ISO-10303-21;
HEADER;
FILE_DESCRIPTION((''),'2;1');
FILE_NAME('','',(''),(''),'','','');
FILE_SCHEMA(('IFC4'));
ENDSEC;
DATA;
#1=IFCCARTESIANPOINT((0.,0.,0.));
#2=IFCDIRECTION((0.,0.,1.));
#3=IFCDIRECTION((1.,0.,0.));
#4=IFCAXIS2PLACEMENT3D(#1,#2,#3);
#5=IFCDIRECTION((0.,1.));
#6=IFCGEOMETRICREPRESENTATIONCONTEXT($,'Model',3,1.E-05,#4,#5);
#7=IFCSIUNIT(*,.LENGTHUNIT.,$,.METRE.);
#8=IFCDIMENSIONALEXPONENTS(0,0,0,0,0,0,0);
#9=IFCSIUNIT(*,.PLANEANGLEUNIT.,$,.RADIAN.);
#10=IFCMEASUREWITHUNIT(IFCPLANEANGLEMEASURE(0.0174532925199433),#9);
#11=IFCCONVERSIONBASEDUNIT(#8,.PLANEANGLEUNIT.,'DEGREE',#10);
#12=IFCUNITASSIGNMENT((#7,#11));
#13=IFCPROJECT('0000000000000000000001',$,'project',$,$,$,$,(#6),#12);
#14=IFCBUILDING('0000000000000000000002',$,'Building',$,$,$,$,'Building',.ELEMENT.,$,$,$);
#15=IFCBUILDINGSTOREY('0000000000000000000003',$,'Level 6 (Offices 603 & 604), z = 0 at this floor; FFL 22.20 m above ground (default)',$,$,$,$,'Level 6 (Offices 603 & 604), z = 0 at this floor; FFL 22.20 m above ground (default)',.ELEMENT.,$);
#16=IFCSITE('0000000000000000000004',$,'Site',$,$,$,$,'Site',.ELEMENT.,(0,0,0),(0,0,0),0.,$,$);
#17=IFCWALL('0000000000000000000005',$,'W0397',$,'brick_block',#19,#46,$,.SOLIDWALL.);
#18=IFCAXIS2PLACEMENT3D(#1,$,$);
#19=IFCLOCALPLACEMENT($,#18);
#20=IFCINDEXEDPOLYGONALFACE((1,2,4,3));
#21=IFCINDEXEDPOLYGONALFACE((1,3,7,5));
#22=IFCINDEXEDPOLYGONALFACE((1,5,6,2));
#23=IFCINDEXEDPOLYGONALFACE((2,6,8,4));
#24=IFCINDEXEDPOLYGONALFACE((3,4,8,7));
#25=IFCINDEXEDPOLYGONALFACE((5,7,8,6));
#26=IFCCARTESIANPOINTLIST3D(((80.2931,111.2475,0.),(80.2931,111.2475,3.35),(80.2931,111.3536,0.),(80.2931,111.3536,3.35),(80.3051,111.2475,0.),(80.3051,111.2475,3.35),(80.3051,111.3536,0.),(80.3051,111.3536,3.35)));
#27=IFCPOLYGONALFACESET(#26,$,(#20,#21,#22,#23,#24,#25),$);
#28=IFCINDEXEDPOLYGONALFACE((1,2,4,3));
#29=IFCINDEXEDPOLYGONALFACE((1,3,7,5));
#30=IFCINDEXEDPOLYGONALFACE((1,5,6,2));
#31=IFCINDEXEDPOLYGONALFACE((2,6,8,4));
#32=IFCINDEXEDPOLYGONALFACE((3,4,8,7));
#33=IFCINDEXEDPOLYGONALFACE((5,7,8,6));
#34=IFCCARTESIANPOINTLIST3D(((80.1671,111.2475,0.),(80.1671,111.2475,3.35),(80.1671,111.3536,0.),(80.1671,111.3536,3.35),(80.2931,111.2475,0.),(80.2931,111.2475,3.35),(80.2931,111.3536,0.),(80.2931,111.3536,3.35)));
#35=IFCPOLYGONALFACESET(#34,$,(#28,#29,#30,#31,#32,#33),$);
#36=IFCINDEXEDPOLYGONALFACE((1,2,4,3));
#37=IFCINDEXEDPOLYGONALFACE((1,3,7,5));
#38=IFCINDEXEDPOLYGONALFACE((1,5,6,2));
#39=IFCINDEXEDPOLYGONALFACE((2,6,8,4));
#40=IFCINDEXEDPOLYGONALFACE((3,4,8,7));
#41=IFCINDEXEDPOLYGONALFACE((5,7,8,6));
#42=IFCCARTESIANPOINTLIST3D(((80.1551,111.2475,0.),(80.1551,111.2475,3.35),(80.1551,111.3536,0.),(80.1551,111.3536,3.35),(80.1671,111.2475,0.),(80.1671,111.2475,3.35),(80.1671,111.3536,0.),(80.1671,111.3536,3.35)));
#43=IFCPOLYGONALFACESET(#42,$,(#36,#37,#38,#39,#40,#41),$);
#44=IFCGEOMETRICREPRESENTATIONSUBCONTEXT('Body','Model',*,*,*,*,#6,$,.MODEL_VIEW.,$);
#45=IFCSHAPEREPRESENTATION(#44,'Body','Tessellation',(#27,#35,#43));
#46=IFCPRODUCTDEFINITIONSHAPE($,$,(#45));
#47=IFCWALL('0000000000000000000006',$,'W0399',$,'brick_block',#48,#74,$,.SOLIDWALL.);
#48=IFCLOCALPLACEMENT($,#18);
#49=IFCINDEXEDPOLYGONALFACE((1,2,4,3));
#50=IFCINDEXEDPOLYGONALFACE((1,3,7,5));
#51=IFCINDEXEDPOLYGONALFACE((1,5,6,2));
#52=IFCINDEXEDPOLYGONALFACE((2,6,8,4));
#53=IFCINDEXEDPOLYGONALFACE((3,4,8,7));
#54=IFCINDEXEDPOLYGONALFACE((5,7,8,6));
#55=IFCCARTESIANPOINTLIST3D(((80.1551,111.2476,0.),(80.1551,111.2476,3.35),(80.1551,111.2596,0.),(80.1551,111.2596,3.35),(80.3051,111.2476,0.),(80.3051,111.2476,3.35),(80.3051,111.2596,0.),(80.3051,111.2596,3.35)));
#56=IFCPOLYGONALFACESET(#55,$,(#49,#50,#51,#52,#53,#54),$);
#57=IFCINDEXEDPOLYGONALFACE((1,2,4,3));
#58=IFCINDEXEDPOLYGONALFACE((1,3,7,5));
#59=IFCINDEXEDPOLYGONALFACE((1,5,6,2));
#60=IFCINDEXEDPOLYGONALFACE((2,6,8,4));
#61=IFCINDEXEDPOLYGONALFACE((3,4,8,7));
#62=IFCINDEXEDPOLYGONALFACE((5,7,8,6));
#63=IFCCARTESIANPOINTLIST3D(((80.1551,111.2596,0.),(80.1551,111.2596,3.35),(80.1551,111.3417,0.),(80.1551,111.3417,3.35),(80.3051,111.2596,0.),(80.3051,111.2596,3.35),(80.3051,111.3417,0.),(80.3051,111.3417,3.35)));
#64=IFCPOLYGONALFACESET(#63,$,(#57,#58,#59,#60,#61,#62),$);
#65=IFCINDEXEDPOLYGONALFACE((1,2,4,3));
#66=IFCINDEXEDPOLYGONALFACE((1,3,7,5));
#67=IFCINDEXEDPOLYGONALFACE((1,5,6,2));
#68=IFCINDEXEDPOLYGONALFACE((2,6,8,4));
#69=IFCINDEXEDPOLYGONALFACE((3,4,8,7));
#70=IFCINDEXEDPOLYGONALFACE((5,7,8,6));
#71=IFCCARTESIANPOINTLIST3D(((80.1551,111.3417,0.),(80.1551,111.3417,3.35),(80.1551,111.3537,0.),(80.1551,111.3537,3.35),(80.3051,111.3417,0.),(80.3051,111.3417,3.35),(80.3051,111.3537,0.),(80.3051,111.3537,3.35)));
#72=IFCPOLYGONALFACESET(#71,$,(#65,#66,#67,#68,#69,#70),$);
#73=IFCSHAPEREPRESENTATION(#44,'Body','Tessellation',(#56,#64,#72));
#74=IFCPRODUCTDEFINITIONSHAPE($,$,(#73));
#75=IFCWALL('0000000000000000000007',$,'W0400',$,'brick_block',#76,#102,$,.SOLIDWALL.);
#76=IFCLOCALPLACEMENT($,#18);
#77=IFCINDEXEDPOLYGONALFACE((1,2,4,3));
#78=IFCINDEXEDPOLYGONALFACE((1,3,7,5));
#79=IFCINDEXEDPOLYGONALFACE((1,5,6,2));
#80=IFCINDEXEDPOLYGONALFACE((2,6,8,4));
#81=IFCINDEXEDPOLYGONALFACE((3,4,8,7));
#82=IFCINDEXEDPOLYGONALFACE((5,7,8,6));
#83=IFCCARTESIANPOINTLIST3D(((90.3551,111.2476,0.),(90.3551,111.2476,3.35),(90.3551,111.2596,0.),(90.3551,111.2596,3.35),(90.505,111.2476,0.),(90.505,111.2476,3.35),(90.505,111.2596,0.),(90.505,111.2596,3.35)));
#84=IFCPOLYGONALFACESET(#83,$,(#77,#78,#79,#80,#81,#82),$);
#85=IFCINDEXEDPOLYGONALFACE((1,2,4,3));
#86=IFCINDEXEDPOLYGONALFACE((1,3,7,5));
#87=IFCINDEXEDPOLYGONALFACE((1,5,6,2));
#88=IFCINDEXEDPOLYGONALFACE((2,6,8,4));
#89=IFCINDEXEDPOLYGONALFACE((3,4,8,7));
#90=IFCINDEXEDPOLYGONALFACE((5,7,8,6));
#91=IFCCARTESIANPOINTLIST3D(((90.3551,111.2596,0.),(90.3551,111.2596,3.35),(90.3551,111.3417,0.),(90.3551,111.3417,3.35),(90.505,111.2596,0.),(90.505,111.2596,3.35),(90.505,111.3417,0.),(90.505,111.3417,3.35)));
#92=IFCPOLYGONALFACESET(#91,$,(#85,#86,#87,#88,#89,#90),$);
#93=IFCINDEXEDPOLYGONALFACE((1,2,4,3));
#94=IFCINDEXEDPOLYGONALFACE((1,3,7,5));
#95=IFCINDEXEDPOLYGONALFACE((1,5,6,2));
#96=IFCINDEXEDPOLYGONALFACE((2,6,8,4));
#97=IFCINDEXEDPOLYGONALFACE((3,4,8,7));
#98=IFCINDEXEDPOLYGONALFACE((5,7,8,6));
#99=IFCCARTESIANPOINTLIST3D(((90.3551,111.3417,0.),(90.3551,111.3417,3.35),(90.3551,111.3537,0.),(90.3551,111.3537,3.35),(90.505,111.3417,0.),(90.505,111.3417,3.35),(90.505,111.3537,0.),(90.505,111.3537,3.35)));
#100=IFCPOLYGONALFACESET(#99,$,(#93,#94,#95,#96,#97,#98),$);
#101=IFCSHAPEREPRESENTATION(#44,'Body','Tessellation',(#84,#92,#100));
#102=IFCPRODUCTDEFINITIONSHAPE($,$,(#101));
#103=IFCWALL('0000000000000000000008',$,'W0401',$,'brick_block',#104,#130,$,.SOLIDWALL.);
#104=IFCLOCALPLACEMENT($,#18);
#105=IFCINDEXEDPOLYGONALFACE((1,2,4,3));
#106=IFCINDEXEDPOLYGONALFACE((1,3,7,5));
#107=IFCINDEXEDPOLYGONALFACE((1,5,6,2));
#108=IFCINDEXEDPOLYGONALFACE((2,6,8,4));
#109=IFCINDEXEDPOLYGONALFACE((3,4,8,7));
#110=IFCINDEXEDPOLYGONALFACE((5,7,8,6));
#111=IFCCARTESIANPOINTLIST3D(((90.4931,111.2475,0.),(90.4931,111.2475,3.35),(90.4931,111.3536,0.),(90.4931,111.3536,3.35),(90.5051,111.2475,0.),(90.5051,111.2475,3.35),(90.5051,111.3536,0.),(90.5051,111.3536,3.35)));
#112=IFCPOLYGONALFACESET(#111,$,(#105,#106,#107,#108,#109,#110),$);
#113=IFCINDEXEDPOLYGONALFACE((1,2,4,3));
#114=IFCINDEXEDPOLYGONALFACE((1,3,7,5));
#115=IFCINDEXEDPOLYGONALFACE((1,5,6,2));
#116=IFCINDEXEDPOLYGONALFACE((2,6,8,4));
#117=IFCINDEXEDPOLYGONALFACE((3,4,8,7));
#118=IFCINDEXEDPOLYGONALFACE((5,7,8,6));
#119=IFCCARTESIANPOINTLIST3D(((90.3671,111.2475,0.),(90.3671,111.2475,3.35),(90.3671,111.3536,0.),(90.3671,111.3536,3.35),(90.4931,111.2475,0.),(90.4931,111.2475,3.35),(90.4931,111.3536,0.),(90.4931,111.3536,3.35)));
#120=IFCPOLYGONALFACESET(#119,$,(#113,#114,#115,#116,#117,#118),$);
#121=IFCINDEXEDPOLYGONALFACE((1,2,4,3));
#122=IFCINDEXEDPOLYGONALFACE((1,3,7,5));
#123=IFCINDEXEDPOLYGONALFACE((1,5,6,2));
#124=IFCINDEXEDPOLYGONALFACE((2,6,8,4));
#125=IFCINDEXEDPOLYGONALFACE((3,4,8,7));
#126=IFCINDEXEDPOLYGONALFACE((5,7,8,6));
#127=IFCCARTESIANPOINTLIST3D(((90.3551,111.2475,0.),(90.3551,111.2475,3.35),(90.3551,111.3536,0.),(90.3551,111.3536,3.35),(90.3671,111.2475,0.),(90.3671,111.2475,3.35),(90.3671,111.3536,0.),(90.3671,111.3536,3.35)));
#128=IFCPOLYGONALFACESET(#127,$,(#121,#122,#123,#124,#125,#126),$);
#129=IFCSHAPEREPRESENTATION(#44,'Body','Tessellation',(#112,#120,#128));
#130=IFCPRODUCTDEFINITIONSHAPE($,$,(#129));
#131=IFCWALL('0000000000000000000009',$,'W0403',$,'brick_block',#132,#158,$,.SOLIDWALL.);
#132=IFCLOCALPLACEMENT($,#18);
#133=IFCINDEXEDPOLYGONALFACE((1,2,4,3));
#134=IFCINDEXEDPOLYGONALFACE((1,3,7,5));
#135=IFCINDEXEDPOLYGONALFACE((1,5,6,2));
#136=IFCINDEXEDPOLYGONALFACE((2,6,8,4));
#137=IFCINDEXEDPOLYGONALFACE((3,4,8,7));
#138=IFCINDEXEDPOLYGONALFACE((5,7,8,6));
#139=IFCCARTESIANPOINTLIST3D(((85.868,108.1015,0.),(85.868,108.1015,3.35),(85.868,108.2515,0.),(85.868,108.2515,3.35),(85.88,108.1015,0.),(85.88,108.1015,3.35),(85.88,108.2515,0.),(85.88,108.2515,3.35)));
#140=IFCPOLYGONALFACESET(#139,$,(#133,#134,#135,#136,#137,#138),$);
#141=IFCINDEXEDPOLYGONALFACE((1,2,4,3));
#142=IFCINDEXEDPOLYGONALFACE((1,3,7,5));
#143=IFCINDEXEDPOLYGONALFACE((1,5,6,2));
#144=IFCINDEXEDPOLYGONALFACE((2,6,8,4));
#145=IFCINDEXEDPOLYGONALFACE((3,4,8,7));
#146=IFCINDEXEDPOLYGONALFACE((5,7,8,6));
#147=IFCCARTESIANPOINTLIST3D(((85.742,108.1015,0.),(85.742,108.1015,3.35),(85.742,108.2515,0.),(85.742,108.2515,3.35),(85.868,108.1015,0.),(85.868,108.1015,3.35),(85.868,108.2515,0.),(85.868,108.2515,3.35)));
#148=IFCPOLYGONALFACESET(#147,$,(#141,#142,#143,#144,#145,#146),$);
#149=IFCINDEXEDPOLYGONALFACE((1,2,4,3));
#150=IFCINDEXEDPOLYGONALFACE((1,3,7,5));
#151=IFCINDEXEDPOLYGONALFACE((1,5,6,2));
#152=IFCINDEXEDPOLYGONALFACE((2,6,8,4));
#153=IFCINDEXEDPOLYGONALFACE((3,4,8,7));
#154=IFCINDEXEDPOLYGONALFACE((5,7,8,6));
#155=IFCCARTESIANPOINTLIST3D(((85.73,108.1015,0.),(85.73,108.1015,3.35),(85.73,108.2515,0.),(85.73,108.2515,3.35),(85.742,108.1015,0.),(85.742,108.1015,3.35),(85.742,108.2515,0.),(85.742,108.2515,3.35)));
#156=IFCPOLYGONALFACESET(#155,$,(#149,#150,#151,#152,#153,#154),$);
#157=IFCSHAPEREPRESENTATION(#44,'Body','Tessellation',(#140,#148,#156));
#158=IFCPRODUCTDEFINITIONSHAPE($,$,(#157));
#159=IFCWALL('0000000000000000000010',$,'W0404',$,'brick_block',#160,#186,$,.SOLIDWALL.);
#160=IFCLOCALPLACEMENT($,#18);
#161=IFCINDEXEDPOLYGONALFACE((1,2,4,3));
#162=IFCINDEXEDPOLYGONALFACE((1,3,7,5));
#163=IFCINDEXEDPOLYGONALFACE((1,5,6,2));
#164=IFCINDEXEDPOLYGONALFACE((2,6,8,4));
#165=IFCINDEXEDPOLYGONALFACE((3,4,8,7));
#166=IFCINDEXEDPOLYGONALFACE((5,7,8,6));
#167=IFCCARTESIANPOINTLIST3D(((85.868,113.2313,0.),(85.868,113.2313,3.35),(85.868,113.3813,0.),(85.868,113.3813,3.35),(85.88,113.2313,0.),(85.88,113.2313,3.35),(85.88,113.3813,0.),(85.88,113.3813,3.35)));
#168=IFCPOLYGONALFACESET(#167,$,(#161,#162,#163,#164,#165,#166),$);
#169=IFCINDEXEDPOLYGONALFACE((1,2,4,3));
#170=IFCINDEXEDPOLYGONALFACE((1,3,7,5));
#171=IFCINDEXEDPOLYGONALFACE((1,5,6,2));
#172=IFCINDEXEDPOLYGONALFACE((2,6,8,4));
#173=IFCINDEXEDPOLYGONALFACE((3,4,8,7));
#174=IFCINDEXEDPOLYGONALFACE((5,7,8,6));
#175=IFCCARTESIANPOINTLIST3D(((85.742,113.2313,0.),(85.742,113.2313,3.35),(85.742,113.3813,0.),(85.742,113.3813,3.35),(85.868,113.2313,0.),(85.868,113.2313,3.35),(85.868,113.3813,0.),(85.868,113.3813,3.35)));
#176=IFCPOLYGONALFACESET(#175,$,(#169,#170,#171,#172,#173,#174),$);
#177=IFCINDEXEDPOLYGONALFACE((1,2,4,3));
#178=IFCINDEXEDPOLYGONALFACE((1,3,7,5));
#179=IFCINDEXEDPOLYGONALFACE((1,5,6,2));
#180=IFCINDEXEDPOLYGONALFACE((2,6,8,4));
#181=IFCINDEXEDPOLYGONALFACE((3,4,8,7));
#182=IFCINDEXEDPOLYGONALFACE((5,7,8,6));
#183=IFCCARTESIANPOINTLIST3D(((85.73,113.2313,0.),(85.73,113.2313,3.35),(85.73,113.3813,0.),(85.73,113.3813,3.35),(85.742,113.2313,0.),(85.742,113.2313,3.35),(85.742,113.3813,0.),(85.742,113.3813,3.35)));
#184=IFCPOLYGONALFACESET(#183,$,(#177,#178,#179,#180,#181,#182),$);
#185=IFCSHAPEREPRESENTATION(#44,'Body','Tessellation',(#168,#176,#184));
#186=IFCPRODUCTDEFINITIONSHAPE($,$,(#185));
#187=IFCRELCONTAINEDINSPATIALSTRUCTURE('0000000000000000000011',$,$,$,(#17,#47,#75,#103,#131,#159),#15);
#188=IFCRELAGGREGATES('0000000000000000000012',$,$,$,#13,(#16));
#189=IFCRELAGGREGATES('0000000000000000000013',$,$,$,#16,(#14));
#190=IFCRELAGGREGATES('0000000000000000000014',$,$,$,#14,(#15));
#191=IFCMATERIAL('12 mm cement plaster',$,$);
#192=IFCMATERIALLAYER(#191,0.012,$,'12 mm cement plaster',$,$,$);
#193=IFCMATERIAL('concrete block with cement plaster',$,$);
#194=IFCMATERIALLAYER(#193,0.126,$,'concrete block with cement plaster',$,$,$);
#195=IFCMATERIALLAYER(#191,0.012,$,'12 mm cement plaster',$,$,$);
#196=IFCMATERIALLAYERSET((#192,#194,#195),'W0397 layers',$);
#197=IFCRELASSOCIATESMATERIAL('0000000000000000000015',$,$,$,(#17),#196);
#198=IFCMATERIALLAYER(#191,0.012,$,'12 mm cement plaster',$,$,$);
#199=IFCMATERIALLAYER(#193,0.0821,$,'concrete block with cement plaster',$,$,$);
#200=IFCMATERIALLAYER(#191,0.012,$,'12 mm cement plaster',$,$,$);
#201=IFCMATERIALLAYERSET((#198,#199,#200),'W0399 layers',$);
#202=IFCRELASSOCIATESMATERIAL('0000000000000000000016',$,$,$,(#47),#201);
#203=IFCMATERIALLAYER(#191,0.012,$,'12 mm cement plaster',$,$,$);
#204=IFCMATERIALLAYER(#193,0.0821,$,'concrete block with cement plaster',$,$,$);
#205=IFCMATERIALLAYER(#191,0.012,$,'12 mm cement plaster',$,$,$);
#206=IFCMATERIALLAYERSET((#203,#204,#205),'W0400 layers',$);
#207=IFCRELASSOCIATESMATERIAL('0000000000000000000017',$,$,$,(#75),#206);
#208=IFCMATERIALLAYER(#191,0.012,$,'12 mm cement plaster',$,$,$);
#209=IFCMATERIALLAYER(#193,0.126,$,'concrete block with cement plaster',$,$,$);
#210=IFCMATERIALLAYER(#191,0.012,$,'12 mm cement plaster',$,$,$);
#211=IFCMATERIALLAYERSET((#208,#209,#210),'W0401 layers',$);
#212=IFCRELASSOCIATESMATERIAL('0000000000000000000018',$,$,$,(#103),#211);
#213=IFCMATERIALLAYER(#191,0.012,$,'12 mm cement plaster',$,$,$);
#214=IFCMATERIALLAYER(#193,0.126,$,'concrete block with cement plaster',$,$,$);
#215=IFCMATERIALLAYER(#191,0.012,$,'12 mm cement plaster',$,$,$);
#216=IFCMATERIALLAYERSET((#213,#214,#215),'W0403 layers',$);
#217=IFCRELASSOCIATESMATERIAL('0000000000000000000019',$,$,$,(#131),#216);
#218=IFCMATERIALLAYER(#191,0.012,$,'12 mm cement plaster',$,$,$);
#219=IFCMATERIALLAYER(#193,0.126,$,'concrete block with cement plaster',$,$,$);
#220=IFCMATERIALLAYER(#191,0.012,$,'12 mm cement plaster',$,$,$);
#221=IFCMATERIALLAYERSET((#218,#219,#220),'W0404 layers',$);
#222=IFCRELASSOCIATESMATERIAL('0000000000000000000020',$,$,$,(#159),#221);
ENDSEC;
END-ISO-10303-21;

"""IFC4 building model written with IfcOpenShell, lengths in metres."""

from ifc_helpers import new_model, entity, si_unit, converted_unit, direction, frame, frame_2d, origin_with_axes, place, context, subcontext, project, spatial, rectangle, extrude, material, layer, layer_set, layer_usage, element, save


model = new_model("IFC4")

# Units and contexts
model_context = context("Model", 3, precision=1e-05, world=origin_with_axes(), true_north=direction((0.0, 1.0)))
body_context = subcontext(model_context, "Body", "Model", "MODEL_VIEW")
ifc_project = project(units=[si_unit("LENGTHUNIT", "METRE"), converted_unit("PLANEANGLEUNIT", "DEGREE", entity("IfcPlaneAngleMeasure", 0.0174532925199433), si_unit("PLANEANGLEUNIT", "RADIAN"), dimensions=[0, 0, 0, 0, 0, 0, 0])], contexts=[model_context])

# Site, building, storey
site = spatial("IfcSite", under=ifc_project, Name="Site", LongName="Site", CompositionType="ELEMENT", RefLatitude=(0, 0, 0), RefLongitude=(0, 0, 0), RefElevation=0.0)
building = spatial("IfcBuilding", under=site, Name="Building", LongName="Building", CompositionType="ELEMENT")
storey = spatial("IfcBuildingStorey", under=building, Name="Level 6 (Offices 603 & 604), z = 0 at this floor; FFL 22.20 m above ground (default)", LongName="Level 6 (Offices 603 & 604), z = 0 at this floor; FFL 22.20 m above ground (default)", CompositionType="ELEMENT")

# Shared definitions
placement = place(None, origin_with_axes())

# Walls
ifc_material_1 = material(Name="12 mm cement plaster")
ifc_material_2 = material(Name="concrete block with cement plaster")
ifc_layer_1 = layer(ifc_material_1, 0.012, Name="12 mm cement plaster")
ifc_layer_2 = layer(ifc_material_2, 0.126, Name="concrete block with cement plaster")
ifc_layer_3 = layer(ifc_material_1, 0.012, Name="12 mm cement plaster")
ifc_layer_set_1 = layer_set([ifc_layer_1, ifc_layer_2, ifc_layer_3], Name="W0397 layers")
ifc_layer_usage_1 = layer_usage(ifc_layer_set_1, "AXIS2", "POSITIVE", -0.075)
element("IfcWall", 1, at=placement, inside=storey, material=ifc_layer_usage_1, Name="W0397", ObjectType="brick_block", PredefinedType="SOLIDWALL", context=body_context, shape_type="SweptSolid", body=[
    extrude(rectangle(XDim=0.1061, YDim=0.012, at=frame_2d((0.0, 0.0), x_axis=(0.0, 1.0))), frame((80.2991, 111.3006, 0.0), z_axis=(0.0, 0.0, 1.0), x_axis=(1.0, 0.0, 0.0)), (0.0, 0.0, 1.0), 3.35),
    extrude(rectangle(XDim=0.1061, YDim=0.126, at=frame_2d((-0.069, 0.0), x_axis=(0.0, 1.0))), frame((80.2991, 111.3006, 0.0), z_axis=(0.0, 0.0, 1.0), x_axis=(1.0, 0.0, 0.0)), (0.0, 0.0, 1.0), 3.35),
    extrude(rectangle(XDim=0.1061, YDim=0.012, at=frame_2d((-0.138, 0.0), x_axis=(0.0, 1.0))), frame((80.2991, 111.3006, 0.0), z_axis=(0.0, 0.0, 1.0), x_axis=(1.0, 0.0, 0.0)), (0.0, 0.0, 1.0), 3.35),
])
ifc_layer_4 = layer(ifc_material_1, 0.012, Name="12 mm cement plaster")
ifc_layer_5 = layer(ifc_material_2, 0.0821, Name="concrete block with cement plaster")
ifc_layer_6 = layer(ifc_material_1, 0.012, Name="12 mm cement plaster")
ifc_layer_set_2 = layer_set([ifc_layer_4, ifc_layer_5, ifc_layer_6], Name="W0399 layers")
ifc_layer_usage_2 = layer_usage(ifc_layer_set_2, "AXIS2", "POSITIVE", -0.053)
element("IfcWall", 2, at=placement, inside=storey, material=ifc_layer_usage_2, Name="W0399", ObjectType="brick_block", PredefinedType="SOLIDWALL", context=body_context, shape_type="SweptSolid", body=[
    extrude(rectangle(XDim=0.15, YDim=0.012, at=frame_2d((0.0, 0.0), x_axis=(1.0, 0.0))), frame((80.2301, 111.2536, 0.0), z_axis=(0.0, 0.0, 1.0), x_axis=(1.0, 0.0, 0.0)), (0.0, 0.0, 1.0), 3.35),
    extrude(rectangle(XDim=0.15, YDim=0.0821, at=frame_2d((0.0, 0.0471), x_axis=(1.0, 0.0))), frame((80.2301, 111.2536, 0.0), z_axis=(0.0, 0.0, 1.0), x_axis=(1.0, 0.0, 0.0)), (0.0, 0.0, 1.0), 3.35),
    extrude(rectangle(XDim=0.15, YDim=0.012, at=frame_2d((0.0, 0.0941), x_axis=(1.0, 0.0))), frame((80.2301, 111.2536, 0.0), z_axis=(0.0, 0.0, 1.0), x_axis=(1.0, 0.0, 0.0)), (0.0, 0.0, 1.0), 3.35),
])
ifc_layer_7 = layer(ifc_material_1, 0.012, Name="12 mm cement plaster")
ifc_layer_8 = layer(ifc_material_2, 0.0821, Name="concrete block with cement plaster")
ifc_layer_9 = layer(ifc_material_1, 0.012, Name="12 mm cement plaster")
ifc_layer_set_3 = layer_set([ifc_layer_7, ifc_layer_8, ifc_layer_9], Name="W0400 layers")
ifc_layer_usage_3 = layer_usage(ifc_layer_set_3, "AXIS2", "POSITIVE", -0.053)
element("IfcWall", 3, at=placement, inside=storey, material=ifc_layer_usage_3, Name="W0400", ObjectType="brick_block", PredefinedType="SOLIDWALL", context=body_context, shape_type="SweptSolid", body=[
    extrude(rectangle(XDim=0.1499, YDim=0.012, at=frame_2d((0.0, 0.0), x_axis=(1.0, 0.0))), frame((90.43, 111.2536, 0.0), z_axis=(0.0, 0.0, 1.0), x_axis=(1.0, 0.0, 0.0)), (0.0, 0.0, 1.0), 3.35),
    extrude(rectangle(XDim=0.1499, YDim=0.0821, at=frame_2d((0.0, 0.0471), x_axis=(1.0, 0.0))), frame((90.43, 111.2536, 0.0), z_axis=(0.0, 0.0, 1.0), x_axis=(1.0, 0.0, 0.0)), (0.0, 0.0, 1.0), 3.35),
    extrude(rectangle(XDim=0.1499, YDim=0.012, at=frame_2d((0.0, 0.0941), x_axis=(1.0, 0.0))), frame((90.43, 111.2536, 0.0), z_axis=(0.0, 0.0, 1.0), x_axis=(1.0, 0.0, 0.0)), (0.0, 0.0, 1.0), 3.35),
])
ifc_layer_10 = layer(ifc_material_1, 0.012, Name="12 mm cement plaster")
ifc_layer_11 = layer(ifc_material_2, 0.126, Name="concrete block with cement plaster")
ifc_layer_12 = layer(ifc_material_1, 0.012, Name="12 mm cement plaster")
ifc_layer_set_4 = layer_set([ifc_layer_10, ifc_layer_11, ifc_layer_12], Name="W0401 layers")
ifc_layer_usage_4 = layer_usage(ifc_layer_set_4, "AXIS2", "POSITIVE", -0.075)
element("IfcWall", 4, at=placement, inside=storey, material=ifc_layer_usage_4, Name="W0401", ObjectType="brick_block", PredefinedType="SOLIDWALL", context=body_context, shape_type="SweptSolid", body=[
    extrude(rectangle(XDim=0.1061, YDim=0.012, at=frame_2d((0.0, 0.0), x_axis=(0.0, 1.0))), frame((90.4991, 111.3006, 0.0), z_axis=(0.0, 0.0, 1.0), x_axis=(1.0, 0.0, 0.0)), (0.0, 0.0, 1.0), 3.35),
    extrude(rectangle(XDim=0.1061, YDim=0.126, at=frame_2d((-0.069, 0.0), x_axis=(0.0, 1.0))), frame((90.4991, 111.3006, 0.0), z_axis=(0.0, 0.0, 1.0), x_axis=(1.0, 0.0, 0.0)), (0.0, 0.0, 1.0), 3.35),
    extrude(rectangle(XDim=0.1061, YDim=0.012, at=frame_2d((-0.138, 0.0), x_axis=(0.0, 1.0))), frame((90.4991, 111.3006, 0.0), z_axis=(0.0, 0.0, 1.0), x_axis=(1.0, 0.0, 0.0)), (0.0, 0.0, 1.0), 3.35),
])
ifc_layer_13 = layer(ifc_material_1, 0.012, Name="12 mm cement plaster")
ifc_layer_14 = layer(ifc_material_2, 0.126, Name="concrete block with cement plaster")
ifc_layer_15 = layer(ifc_material_1, 0.012, Name="12 mm cement plaster")
ifc_layer_set_5 = layer_set([ifc_layer_13, ifc_layer_14, ifc_layer_15], Name="W0403 layers")
ifc_layer_usage_5 = layer_usage(ifc_layer_set_5, "AXIS2", "POSITIVE", -0.075)
element("IfcWall", 5, at=placement, inside=storey, material=ifc_layer_usage_5, Name="W0403", ObjectType="brick_block", PredefinedType="SOLIDWALL", context=body_context, shape_type="SweptSolid", body=[
    extrude(rectangle(XDim=0.15, YDim=0.012, at=frame_2d((0.0, 0.0), x_axis=(0.0, 1.0))), frame((85.874, 108.1765, 0.0), z_axis=(0.0, 0.0, 1.0), x_axis=(1.0, 0.0, 0.0)), (0.0, 0.0, 1.0), 3.35),
    extrude(rectangle(XDim=0.15, YDim=0.126, at=frame_2d((-0.069, 0.0), x_axis=(0.0, 1.0))), frame((85.874, 108.1765, 0.0), z_axis=(0.0, 0.0, 1.0), x_axis=(1.0, 0.0, 0.0)), (0.0, 0.0, 1.0), 3.35),
    extrude(rectangle(XDim=0.15, YDim=0.012, at=frame_2d((-0.138, 0.0), x_axis=(0.0, 1.0))), frame((85.874, 108.1765, 0.0), z_axis=(0.0, 0.0, 1.0), x_axis=(1.0, 0.0, 0.0)), (0.0, 0.0, 1.0), 3.35),
])
ifc_layer_16 = layer(ifc_material_1, 0.012, Name="12 mm cement plaster")
ifc_layer_17 = layer(ifc_material_2, 0.126, Name="concrete block with cement plaster")
ifc_layer_18 = layer(ifc_material_1, 0.012, Name="12 mm cement plaster")
ifc_layer_set_6 = layer_set([ifc_layer_16, ifc_layer_17, ifc_layer_18], Name="W0404 layers")
ifc_layer_usage_6 = layer_usage(ifc_layer_set_6, "AXIS2", "POSITIVE", -0.075)
element("IfcWall", 6, at=placement, inside=storey, material=ifc_layer_usage_6, Name="W0404", ObjectType="brick_block", PredefinedType="SOLIDWALL", context=body_context, shape_type="SweptSolid", body=[
    extrude(rectangle(XDim=0.15, YDim=0.012, at=frame_2d((0.0, 0.0), x_axis=(0.0, 1.0))), frame((85.874, 113.3063, 0.0), z_axis=(0.0, 0.0, 1.0), x_axis=(1.0, 0.0, 0.0)), (0.0, 0.0, 1.0), 3.35),
    extrude(rectangle(XDim=0.15, YDim=0.126, at=frame_2d((-0.069, 0.0), x_axis=(0.0, 1.0))), frame((85.874, 113.3063, 0.0), z_axis=(0.0, 0.0, 1.0), x_axis=(1.0, 0.0, 0.0)), (0.0, 0.0, 1.0), 3.35),
    extrude(rectangle(XDim=0.15, YDim=0.012, at=frame_2d((-0.138, 0.0), x_axis=(0.0, 1.0))), frame((85.874, 113.3063, 0.0), z_axis=(0.0, 0.0, 1.0), x_axis=(1.0, 0.0, 0.0)), (0.0, 0.0, 1.0), 3.35),
])

save(model, "model.ifc")
